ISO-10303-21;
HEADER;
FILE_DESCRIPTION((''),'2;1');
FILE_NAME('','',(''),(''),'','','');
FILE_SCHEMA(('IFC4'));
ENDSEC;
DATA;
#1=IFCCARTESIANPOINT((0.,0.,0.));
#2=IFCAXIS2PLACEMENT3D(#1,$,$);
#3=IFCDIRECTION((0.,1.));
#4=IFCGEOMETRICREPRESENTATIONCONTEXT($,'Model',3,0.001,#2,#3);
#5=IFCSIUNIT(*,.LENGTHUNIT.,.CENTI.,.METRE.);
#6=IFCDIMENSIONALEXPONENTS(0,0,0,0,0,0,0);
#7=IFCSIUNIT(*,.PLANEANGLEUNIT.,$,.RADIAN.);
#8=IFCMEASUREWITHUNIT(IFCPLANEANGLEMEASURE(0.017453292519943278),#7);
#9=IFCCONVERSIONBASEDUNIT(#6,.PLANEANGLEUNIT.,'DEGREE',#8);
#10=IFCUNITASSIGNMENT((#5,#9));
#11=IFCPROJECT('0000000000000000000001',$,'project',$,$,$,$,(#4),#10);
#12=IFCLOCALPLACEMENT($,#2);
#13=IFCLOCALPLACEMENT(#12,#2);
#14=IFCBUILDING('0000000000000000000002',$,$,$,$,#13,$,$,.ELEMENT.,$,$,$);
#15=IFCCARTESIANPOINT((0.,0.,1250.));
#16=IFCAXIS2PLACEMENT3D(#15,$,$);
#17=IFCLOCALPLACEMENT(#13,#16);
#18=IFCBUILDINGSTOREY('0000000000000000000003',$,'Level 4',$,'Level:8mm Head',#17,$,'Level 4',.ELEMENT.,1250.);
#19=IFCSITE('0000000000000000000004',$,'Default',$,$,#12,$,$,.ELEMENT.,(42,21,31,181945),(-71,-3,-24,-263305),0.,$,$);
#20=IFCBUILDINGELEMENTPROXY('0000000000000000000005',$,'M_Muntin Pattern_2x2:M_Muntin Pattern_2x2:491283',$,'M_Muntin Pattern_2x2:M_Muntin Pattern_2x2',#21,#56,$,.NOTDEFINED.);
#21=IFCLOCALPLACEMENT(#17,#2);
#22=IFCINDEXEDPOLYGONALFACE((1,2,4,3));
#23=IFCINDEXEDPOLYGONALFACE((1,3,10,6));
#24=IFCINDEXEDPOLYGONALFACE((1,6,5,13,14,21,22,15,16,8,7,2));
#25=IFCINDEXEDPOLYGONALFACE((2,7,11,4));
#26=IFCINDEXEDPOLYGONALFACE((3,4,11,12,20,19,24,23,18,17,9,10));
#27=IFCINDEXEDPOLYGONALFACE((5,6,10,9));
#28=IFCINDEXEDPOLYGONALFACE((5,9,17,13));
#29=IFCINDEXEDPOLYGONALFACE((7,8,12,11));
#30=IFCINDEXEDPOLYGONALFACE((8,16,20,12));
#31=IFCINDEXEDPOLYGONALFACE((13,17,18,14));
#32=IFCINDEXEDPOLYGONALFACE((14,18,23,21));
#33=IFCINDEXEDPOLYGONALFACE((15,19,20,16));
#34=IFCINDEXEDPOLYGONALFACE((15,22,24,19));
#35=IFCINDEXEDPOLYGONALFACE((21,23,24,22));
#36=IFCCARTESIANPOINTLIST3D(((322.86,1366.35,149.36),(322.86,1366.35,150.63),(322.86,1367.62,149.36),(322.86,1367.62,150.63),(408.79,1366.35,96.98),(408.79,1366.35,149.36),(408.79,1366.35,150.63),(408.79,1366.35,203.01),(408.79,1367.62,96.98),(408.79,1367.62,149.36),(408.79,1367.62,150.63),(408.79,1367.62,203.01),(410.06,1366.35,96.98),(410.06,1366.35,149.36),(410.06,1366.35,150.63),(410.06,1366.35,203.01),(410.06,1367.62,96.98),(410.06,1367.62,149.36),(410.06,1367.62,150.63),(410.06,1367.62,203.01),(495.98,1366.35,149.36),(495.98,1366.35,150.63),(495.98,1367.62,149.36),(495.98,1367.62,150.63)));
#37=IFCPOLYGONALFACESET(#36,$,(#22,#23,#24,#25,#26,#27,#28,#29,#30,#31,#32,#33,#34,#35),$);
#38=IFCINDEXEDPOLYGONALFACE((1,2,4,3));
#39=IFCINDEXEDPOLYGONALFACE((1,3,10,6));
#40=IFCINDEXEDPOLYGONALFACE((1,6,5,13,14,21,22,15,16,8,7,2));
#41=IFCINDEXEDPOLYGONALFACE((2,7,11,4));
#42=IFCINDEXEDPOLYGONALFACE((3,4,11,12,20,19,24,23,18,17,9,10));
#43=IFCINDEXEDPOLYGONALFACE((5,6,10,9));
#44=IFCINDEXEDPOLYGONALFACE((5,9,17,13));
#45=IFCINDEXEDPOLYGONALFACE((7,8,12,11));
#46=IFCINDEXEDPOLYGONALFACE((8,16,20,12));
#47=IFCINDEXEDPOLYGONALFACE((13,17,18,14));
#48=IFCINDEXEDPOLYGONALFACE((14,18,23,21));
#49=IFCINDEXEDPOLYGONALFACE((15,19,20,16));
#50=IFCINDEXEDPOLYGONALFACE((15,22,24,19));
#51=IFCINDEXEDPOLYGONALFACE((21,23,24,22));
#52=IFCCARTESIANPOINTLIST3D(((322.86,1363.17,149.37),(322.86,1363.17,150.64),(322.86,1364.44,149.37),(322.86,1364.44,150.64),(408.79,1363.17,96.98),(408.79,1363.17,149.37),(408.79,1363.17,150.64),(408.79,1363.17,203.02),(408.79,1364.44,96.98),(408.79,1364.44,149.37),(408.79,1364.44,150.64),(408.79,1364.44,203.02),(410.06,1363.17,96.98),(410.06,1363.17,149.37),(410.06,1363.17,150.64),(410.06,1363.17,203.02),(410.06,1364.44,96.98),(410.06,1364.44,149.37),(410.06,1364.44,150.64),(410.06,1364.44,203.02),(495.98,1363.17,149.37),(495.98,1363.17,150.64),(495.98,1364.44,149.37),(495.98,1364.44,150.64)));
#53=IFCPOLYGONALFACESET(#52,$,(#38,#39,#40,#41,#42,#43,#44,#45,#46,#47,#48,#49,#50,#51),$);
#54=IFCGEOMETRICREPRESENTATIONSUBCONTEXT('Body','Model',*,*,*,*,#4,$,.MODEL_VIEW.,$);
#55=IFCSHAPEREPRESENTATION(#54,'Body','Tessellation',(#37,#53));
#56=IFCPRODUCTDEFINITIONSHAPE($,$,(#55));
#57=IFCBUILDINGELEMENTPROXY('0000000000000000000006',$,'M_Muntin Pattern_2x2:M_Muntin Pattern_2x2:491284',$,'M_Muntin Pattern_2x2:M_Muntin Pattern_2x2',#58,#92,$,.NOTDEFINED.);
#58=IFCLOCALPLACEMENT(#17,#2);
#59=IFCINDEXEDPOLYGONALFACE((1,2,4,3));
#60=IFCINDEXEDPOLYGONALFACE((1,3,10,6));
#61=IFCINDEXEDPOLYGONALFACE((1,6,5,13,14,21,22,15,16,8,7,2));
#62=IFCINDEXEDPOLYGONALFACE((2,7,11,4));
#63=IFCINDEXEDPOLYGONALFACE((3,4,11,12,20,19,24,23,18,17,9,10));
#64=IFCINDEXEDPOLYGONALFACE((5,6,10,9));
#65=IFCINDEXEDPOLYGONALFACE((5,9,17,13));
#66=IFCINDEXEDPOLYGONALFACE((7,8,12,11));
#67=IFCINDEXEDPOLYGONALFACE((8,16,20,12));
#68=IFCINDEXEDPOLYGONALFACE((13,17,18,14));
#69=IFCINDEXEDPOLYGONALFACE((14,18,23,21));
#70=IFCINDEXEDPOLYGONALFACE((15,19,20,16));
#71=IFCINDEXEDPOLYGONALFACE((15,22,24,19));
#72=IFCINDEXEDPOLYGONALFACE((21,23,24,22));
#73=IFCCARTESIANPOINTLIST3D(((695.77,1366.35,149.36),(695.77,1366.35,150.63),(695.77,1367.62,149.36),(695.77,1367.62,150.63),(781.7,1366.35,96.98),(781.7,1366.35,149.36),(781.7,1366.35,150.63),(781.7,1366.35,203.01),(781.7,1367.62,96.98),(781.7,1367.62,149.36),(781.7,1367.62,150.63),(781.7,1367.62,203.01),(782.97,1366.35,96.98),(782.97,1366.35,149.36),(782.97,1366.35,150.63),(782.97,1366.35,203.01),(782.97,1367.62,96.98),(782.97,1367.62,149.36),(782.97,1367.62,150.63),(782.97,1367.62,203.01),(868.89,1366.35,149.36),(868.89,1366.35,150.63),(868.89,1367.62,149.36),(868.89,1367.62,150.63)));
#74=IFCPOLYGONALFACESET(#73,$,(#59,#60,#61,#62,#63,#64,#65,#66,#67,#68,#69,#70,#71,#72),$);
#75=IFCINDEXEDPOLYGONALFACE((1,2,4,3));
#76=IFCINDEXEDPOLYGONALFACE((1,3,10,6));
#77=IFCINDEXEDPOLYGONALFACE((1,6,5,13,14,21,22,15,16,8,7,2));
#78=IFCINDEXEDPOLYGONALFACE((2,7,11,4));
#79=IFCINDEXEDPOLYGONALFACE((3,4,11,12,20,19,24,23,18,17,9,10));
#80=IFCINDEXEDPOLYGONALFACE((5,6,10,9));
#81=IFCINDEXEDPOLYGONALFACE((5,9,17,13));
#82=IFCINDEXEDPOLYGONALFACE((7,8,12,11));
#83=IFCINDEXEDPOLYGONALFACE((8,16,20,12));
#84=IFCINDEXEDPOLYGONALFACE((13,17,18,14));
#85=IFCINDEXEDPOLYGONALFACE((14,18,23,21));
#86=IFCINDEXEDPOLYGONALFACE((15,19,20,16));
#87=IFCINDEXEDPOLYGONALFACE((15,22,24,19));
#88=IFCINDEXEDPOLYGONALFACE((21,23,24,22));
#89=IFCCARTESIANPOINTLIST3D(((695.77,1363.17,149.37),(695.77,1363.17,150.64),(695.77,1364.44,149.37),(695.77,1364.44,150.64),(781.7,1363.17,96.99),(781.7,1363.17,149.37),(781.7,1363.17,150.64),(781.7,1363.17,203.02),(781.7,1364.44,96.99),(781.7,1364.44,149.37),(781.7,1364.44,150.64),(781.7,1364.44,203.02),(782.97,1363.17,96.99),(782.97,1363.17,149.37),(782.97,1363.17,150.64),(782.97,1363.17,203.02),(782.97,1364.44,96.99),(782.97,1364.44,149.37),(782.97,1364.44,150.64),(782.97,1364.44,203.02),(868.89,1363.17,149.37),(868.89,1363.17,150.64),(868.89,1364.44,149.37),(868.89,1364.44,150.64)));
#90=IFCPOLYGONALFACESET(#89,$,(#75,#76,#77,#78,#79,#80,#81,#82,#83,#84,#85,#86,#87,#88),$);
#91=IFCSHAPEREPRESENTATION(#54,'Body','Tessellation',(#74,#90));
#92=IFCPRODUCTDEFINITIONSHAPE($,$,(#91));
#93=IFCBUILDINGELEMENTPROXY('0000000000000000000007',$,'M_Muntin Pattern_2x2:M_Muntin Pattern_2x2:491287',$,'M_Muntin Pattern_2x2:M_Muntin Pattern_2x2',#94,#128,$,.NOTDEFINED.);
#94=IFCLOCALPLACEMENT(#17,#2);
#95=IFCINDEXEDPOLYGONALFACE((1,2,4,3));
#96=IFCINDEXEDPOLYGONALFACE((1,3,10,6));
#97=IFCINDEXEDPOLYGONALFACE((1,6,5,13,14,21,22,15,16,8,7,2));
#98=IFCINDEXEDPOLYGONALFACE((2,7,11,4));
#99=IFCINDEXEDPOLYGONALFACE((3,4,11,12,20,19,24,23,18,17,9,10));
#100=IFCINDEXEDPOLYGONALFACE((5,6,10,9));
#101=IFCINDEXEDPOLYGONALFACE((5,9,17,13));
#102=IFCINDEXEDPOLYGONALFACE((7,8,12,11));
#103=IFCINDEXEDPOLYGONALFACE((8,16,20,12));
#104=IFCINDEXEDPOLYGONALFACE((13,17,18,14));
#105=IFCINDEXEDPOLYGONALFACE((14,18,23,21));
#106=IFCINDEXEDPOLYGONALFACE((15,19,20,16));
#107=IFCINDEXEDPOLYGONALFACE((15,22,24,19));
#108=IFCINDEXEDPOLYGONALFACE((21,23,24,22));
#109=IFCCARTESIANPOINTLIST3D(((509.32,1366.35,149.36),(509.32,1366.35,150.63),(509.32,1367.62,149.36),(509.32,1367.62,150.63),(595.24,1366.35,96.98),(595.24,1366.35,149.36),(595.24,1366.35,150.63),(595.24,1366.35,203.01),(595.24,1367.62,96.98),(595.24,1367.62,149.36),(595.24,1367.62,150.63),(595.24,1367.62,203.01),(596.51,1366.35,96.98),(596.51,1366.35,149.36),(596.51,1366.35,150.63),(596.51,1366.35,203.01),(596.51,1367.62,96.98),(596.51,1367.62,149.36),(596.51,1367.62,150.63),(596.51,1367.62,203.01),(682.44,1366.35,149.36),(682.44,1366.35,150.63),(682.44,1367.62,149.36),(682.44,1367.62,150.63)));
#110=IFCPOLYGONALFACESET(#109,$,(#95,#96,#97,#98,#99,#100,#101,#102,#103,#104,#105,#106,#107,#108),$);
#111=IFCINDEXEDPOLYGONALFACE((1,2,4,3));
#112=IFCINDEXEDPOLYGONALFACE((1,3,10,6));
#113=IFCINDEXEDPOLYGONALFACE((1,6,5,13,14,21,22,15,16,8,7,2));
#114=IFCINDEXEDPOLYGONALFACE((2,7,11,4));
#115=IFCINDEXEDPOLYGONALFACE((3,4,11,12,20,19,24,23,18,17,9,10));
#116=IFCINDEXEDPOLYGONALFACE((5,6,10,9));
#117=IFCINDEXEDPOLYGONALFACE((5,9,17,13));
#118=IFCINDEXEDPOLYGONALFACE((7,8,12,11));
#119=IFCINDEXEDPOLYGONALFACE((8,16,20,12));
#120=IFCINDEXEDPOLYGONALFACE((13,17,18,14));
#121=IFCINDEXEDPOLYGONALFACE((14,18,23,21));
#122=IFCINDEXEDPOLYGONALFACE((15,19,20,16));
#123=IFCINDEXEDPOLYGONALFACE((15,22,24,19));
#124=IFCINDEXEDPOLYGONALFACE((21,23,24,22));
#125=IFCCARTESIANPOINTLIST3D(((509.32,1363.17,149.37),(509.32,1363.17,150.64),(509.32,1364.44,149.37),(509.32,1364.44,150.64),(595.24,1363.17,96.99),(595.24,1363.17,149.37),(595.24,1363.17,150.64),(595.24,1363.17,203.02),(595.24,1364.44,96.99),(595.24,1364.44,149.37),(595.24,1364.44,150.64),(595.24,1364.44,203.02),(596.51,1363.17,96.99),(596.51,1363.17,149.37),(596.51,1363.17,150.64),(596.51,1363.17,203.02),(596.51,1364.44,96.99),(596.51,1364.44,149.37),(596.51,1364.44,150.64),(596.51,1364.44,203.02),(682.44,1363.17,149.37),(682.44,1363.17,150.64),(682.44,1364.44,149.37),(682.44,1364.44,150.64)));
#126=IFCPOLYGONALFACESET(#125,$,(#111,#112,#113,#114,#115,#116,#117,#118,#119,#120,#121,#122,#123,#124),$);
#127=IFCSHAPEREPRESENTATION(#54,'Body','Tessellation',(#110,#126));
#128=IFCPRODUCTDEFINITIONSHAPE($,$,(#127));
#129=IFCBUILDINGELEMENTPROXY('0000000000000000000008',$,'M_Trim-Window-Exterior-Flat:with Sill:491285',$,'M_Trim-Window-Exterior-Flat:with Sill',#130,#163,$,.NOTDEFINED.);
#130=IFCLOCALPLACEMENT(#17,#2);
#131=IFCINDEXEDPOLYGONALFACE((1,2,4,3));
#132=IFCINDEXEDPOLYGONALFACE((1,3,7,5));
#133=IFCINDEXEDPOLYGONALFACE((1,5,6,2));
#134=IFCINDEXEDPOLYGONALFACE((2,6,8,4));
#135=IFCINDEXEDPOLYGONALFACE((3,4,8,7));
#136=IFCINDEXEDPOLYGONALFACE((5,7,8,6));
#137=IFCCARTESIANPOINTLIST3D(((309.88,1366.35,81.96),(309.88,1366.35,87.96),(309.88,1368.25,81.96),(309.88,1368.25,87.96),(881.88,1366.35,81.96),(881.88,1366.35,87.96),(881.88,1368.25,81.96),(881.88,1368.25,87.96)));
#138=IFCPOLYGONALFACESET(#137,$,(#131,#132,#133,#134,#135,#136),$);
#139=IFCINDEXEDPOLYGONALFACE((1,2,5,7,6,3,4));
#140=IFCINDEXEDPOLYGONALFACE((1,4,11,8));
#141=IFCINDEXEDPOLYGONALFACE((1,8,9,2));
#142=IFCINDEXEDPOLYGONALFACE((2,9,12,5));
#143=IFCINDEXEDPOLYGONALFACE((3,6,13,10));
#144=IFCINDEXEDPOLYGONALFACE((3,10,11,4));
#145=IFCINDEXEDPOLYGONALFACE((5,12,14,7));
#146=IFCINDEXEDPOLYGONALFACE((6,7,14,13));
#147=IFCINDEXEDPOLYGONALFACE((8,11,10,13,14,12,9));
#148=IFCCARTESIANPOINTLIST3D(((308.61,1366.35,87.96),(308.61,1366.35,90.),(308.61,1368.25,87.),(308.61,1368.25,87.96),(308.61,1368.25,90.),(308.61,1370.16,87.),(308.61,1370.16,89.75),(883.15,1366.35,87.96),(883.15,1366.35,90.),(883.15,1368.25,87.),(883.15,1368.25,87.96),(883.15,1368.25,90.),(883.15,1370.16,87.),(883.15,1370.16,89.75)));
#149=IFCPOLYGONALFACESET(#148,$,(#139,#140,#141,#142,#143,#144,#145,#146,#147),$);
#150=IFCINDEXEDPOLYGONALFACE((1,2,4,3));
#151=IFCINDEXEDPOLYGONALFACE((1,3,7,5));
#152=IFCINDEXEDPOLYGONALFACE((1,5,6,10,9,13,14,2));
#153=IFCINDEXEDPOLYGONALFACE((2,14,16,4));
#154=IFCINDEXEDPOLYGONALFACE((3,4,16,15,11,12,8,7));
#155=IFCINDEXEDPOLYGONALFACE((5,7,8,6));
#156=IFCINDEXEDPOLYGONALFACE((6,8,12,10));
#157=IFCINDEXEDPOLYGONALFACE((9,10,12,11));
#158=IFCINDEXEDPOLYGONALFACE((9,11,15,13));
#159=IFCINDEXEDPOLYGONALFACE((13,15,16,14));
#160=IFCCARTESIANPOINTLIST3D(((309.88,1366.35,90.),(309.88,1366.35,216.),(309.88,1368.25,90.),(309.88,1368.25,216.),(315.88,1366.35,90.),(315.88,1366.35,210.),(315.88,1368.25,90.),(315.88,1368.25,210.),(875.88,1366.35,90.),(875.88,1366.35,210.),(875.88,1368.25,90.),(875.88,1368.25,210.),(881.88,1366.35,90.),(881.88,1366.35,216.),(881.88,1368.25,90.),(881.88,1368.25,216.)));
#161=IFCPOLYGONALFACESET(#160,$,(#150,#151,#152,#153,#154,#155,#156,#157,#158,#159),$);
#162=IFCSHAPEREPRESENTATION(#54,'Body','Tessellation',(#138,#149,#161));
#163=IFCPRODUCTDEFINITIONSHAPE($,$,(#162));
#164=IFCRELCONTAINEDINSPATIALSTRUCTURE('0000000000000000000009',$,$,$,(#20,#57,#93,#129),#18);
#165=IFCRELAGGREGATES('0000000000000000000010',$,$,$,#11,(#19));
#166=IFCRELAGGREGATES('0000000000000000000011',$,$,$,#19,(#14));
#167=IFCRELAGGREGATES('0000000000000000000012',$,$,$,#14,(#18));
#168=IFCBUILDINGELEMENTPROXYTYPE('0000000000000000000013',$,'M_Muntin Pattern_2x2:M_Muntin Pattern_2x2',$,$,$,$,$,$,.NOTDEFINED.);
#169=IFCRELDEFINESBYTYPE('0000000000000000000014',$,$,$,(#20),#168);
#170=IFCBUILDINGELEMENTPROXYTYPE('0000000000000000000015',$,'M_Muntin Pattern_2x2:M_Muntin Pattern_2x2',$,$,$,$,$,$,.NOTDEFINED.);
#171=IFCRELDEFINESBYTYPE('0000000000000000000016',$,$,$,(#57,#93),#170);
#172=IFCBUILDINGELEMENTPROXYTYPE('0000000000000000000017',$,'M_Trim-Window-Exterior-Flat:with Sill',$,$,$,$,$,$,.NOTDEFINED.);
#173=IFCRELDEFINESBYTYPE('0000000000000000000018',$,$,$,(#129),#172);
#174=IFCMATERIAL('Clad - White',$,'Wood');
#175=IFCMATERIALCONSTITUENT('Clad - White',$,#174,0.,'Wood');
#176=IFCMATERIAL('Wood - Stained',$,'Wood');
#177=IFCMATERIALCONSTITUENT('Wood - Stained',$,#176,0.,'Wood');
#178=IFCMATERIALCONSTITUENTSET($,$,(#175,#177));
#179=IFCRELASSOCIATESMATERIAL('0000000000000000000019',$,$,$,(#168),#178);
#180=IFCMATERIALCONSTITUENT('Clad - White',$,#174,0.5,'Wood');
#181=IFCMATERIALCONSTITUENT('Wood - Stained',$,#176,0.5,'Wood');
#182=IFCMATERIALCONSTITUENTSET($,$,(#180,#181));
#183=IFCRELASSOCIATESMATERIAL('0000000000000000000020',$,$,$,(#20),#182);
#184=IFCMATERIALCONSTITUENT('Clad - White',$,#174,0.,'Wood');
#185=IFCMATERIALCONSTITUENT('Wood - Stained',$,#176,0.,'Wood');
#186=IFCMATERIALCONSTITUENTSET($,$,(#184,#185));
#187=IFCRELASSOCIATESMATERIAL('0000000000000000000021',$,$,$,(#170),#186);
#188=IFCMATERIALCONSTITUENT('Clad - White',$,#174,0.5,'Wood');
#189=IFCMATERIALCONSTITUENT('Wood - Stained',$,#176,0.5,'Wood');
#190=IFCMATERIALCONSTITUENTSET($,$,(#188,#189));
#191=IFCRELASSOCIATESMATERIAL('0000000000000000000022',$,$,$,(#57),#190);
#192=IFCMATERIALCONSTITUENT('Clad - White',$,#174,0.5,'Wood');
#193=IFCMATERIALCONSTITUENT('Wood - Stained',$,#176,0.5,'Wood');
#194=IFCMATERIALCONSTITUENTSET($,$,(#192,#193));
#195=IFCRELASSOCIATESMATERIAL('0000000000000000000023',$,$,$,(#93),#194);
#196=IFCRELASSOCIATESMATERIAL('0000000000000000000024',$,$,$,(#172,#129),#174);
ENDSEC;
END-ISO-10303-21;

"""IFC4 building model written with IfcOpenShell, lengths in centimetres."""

from ifc_helpers import new_model, entity, si_unit, converted_unit, direction, frame, origin, place, context, subcontext, project, spatial, indexed_curve, outline, extrude, source, transform, mapped, material, constituent, constituent_set, type_object, type_shapes, element, save


model = new_model("IFC4")

# Units and contexts
model_context = context("Model", 3, precision=0.001, world=origin(), true_north=direction((0.0, 1.0)))
body_context = subcontext(model_context, "Body", "Model", "MODEL_VIEW")
ifc_project = project(units=[si_unit("LENGTHUNIT", "METRE", prefix="CENTI"), converted_unit("PLANEANGLEUNIT", "DEGREE", entity("IfcPlaneAngleMeasure", 0.017453292519943278), si_unit("PLANEANGLEUNIT", "RADIAN"), dimensions=[0, 0, 0, 0, 0, 0, 0])], contexts=[model_context])

# Site, building, storey
site_placement = place(None, origin())
site = spatial("IfcSite", under=ifc_project, at=site_placement, Name="Default", CompositionType="ELEMENT", RefLatitude=(42, 21, 31, 181945), RefLongitude=(-71, -3, -24, -263305), RefElevation=0.0)
building_placement = place(site_placement, origin())
building = spatial("IfcBuilding", under=site, at=building_placement, CompositionType="ELEMENT")
storey_placement = place(building_placement, frame((0.0, 0.0, 1250.0)))
storey = spatial("IfcBuildingStorey", under=building, at=storey_placement, Name="Level 4", ObjectType="Level:8mm Head", LongName="Level 4", CompositionType="ELEMENT", Elevation=1250.0)

# Building element proxies
ifc_material_1 = material(Name="Clad - White", Category="Wood")
ifc_constituent_1 = constituent(ifc_material_1, Name="Clad - White", Category="Wood", fraction=0.5)
ifc_material_2 = material(Name="Wood - Stained", Category="Wood")
ifc_constituent_2 = constituent(ifc_material_2, Name="Wood - Stained", Category="Wood", fraction=0.5)
ifc_constituent_set_1 = constituent_set(constituents=[ifc_constituent_1, ifc_constituent_2])
ifc_constituent_3 = constituent(ifc_material_1, Name="Clad - White", Category="Wood", fraction=0.0)
ifc_constituent_4 = constituent(ifc_material_2, Name="Wood - Stained", Category="Wood", fraction=0.0)
ifc_constituent_set_2 = constituent_set(constituents=[ifc_constituent_3, ifc_constituent_4])
building_element_proxy_type_1 = type_object("IfcBuildingElementProxyType", Name="M_Muntin Pattern_2x2:M_Muntin Pattern_2x2", PredefinedType="NOTDEFINED", material=ifc_constituent_set_2)
shared_shape_1 = source(origin(), body_context, "Body", "SweptSolid", [
    extrude(outline(indexed_curve([(0.64, -0.64), (53.01, -0.64), (53.01, 0.63), (0.64, 0.63), (0.64, 86.56), (-0.63, 86.56), (-0.63, 0.63), (-53.02, 0.63), (-53.02, -0.64), (-0.63, -0.64), (-0.63, -86.56), (0.64, -86.56), (0.64, -0.64)], self_intersect=False)), frame((0.0, 0.95, 53.01), z_axis=(0.0, 1.0, 0.0), x_axis=(0.0, 0.0, 1.0)), (0.0, 0.0, 1.0), 1.27),
    extrude(outline(indexed_curve([(0.64, -0.64), (53.02, -0.64), (53.02, 0.63), (0.64, 0.63), (0.64, 86.56), (-0.63, 86.56), (-0.63, 0.63), (-53.02, 0.63), (-53.02, -0.64), (-0.63, -0.64), (-0.63, -86.56), (0.64, -86.56), (0.64, -0.64)], self_intersect=False)), frame((0.0, -2.22, 53.02), z_axis=(0.0, 1.0, 0.0), x_axis=(0.0, 0.0, 1.0)), (0.0, 0.0, 1.0), 1.27),
])
type_shapes(building_element_proxy_type_1, [shared_shape_1])
proxy_1_placement = place(storey_placement, frame((409.42, 1365.39, 96.98)))
element("IfcBuildingElementProxy", 1, at=proxy_1_placement, inside=storey, type_object=building_element_proxy_type_1, material=ifc_constituent_set_1, Name="M_Muntin Pattern_2x2:M_Muntin Pattern_2x2:491283", ObjectType="M_Muntin Pattern_2x2:M_Muntin Pattern_2x2", PredefinedType="NOTDEFINED", context=body_context, shape_type="MappedRepresentation", body=[
    mapped(shared_shape_1, transform((0.0, 0.0, 0.0), scale=1.0)),
])
ifc_constituent_5 = constituent(ifc_material_1, Name="Clad - White", Category="Wood", fraction=0.5)
ifc_constituent_6 = constituent(ifc_material_2, Name="Wood - Stained", Category="Wood", fraction=0.5)
ifc_constituent_set_3 = constituent_set(constituents=[ifc_constituent_5, ifc_constituent_6])
ifc_constituent_7 = constituent(ifc_material_1, Name="Clad - White", Category="Wood", fraction=0.0)
ifc_constituent_8 = constituent(ifc_material_2, Name="Wood - Stained", Category="Wood", fraction=0.0)
ifc_constituent_set_4 = constituent_set(constituents=[ifc_constituent_7, ifc_constituent_8])
building_element_proxy_type_2 = type_object("IfcBuildingElementProxyType", Name="M_Muntin Pattern_2x2:M_Muntin Pattern_2x2", PredefinedType="NOTDEFINED", material=ifc_constituent_set_4)
shared_shape_2 = source(origin(), body_context, "Body", "SweptSolid", [
    extrude(outline(indexed_curve([(0.64, -0.64), (53.01, -0.64), (53.01, 0.63), (0.64, 0.63), (0.64, 86.56), (-0.63, 86.56), (-0.63, 0.63), (-53.02, 0.63), (-53.02, -0.64), (-0.63, -0.64), (-0.63, -86.56), (0.64, -86.56), (0.64, -0.64)], self_intersect=False)), frame((0.0, -2.22, 53.01), z_axis=(0.0, 1.0, 0.0), x_axis=(0.0, 0.0, 1.0)), (0.0, 0.0, 1.0), 1.27),
    extrude(outline(indexed_curve([(0.64, -0.64), (53.02, -0.64), (53.02, 0.63), (0.64, 0.63), (0.64, 86.56), (-0.63, 86.56), (-0.63, 0.63), (-53.02, 0.63), (-53.02, -0.64), (-0.63, -0.64), (-0.63, -86.56), (0.64, -86.56), (0.64, -0.64)], self_intersect=False)), frame((0.0, 0.95, 53.02), z_axis=(0.0, 1.0, 0.0), x_axis=(0.0, 0.0, 1.0)), (0.0, 0.0, 1.0), 1.27),
])
type_shapes(building_element_proxy_type_2, [shared_shape_2])
proxy_2_placement = place(storey_placement, frame((782.33, 1365.39, 96.99), z_axis=(0.0, 0.0, 1.0), x_axis=(-1.0, 0.0, 0.0)))
element("IfcBuildingElementProxy", 2, at=proxy_2_placement, inside=storey, type_object=building_element_proxy_type_2, material=ifc_constituent_set_3, Name="M_Muntin Pattern_2x2:M_Muntin Pattern_2x2:491284", ObjectType="M_Muntin Pattern_2x2:M_Muntin Pattern_2x2", PredefinedType="NOTDEFINED", context=body_context, shape_type="MappedRepresentation", body=[
    mapped(shared_shape_2, transform((0.0, 0.0, 0.0), scale=1.0)),
])
ifc_constituent_9 = constituent(ifc_material_1, Name="Clad - White", Category="Wood", fraction=0.5)
ifc_constituent_10 = constituent(ifc_material_2, Name="Wood - Stained", Category="Wood", fraction=0.5)
ifc_constituent_set_5 = constituent_set(constituents=[ifc_constituent_9, ifc_constituent_10])
proxy_3_placement = place(storey_placement, frame((595.88, 1365.39, 96.99), z_axis=(0.0, 0.0, 1.0), x_axis=(-1.0, 0.0, 0.0)))
element("IfcBuildingElementProxy", 3, at=proxy_3_placement, inside=storey, type_object=building_element_proxy_type_2, material=ifc_constituent_set_5, Name="M_Muntin Pattern_2x2:M_Muntin Pattern_2x2:491287", ObjectType="M_Muntin Pattern_2x2:M_Muntin Pattern_2x2", PredefinedType="NOTDEFINED", context=body_context, shape_type="MappedRepresentation", body=[
    mapped(shared_shape_2, transform((0.0, 0.0, 0.0), scale=1.0)),
])
building_element_proxy_type_3 = type_object("IfcBuildingElementProxyType", Name="M_Trim-Window-Exterior-Flat:with Sill", PredefinedType="NOTDEFINED", material=ifc_material_1)
shared_shape_3 = source(origin(), body_context, "Body", "SweptSolid", [
    extrude(outline(indexed_curve([(-286.0, -3.0), (286.0, -3.0), (286.0, 3.0), (-286.0, 3.0), (-286.0, -3.0)], self_intersect=False)), frame((0.0, -125.04, 0.0), z_axis=(0.0, 0.0, 1.0), x_axis=(-1.0, 0.0, 0.0)), (0.0, 0.0, 1.0), 1.9),
    extrude(outline(indexed_curve([(-1.9, -1.52), (0.0, -1.52), (0.0, -0.57), (1.9, -0.57), (1.9, 1.48), (0.0, 1.48), (-1.9, 1.23), (-1.9, -1.52)], self_intersect=False)), frame((-287.27, -121.48, 1.9), z_axis=(1.0, 0.0, 0.0), x_axis=(0.0, 0.0, -1.0)), (0.0, 0.0, 1.0), 574.54),
    extrude(outline(indexed_curve([(-64.5, -286.0), (61.5, -286.0), (61.5, -280.0), (-58.5, -280.0), (-58.5, 280.0), (61.5, 280.0), (61.5, 286.0), (-64.5, 286.0), (-64.5, -286.0)], self_intersect=False)), frame((0.0, -58.5, 0.0), z_axis=(0.0, 0.0, 1.0), x_axis=(0.0, -1.0, 0.0)), (0.0, 0.0, 1.0), 1.9),
])
type_shapes(building_element_proxy_type_3, [shared_shape_3])
proxy_4_placement = place(storey_placement, frame((595.88, 1366.35, 210.0), z_axis=(0.0, 1.0, 0.0), x_axis=(-1.0, 0.0, 0.0)))
element("IfcBuildingElementProxy", 4, at=proxy_4_placement, inside=storey, type_object=building_element_proxy_type_3, material=ifc_material_1, Name="M_Trim-Window-Exterior-Flat:with Sill:491285", ObjectType="M_Trim-Window-Exterior-Flat:with Sill", PredefinedType="NOTDEFINED", context=body_context, shape_type="MappedRepresentation", body=[
    mapped(shared_shape_3, transform((0.0, 0.0, 0.0), scale=1.0)),
])

save(model, "model.ifc")
